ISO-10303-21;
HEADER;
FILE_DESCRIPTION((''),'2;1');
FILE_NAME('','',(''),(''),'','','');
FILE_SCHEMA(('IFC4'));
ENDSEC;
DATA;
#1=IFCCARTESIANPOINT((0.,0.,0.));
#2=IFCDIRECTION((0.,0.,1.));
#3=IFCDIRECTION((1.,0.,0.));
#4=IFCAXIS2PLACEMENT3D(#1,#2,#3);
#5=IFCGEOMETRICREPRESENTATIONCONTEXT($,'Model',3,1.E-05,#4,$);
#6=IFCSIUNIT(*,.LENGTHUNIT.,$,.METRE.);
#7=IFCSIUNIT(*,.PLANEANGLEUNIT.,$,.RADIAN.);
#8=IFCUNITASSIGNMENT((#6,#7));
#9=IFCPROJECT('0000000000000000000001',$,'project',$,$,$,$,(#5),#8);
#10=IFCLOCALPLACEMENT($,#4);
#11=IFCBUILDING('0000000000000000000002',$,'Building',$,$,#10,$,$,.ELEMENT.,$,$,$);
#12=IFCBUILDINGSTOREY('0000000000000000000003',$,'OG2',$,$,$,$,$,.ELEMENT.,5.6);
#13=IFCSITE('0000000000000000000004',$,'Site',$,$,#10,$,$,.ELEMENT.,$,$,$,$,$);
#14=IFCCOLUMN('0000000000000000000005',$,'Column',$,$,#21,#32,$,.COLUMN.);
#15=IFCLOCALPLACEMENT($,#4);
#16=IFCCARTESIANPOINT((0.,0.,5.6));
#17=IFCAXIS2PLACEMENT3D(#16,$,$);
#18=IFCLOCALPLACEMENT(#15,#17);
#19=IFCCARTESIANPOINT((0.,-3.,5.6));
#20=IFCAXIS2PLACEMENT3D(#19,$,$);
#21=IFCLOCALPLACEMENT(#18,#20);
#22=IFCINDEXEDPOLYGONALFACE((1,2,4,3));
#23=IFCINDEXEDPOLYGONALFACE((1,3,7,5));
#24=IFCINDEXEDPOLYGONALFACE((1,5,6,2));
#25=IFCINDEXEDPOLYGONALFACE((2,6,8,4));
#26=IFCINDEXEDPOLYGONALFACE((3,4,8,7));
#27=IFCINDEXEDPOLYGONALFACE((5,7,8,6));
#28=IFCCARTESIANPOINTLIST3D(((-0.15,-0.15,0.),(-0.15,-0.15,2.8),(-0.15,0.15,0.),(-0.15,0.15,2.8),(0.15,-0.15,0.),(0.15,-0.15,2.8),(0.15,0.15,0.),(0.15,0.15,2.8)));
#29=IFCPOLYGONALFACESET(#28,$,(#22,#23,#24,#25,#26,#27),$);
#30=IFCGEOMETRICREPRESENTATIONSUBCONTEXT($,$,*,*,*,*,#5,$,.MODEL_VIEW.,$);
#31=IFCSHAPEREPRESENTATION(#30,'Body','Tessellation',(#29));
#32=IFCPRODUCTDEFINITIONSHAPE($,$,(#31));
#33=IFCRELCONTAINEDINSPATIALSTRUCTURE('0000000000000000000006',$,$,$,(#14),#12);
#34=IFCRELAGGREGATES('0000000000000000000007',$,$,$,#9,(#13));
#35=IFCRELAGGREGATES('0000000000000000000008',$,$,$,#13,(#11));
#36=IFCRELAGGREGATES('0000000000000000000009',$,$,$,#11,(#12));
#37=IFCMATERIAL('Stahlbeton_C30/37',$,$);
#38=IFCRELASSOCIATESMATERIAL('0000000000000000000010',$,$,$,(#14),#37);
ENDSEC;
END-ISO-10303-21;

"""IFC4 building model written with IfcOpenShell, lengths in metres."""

from ifc_helpers import new_model, si_unit, frame, origin, origin_with_axes, origin_2d, place, context, subcontext, project, spatial, rectangle, extrude, material, element, save


model = new_model("IFC4")

# Units and contexts
model_context = context("Model", 3, precision=1e-05, world=origin_with_axes())
sub_context = subcontext(model_context, None, None, "MODEL_VIEW")
ifc_project = project(units=[si_unit("LENGTHUNIT", "METRE"), si_unit("PLANEANGLEUNIT", "RADIAN")], contexts=[model_context])

# Site, building, storey
placement_1 = place(None, origin_with_axes())
site = spatial("IfcSite", under=ifc_project, at=placement_1, Name="Site", CompositionType="ELEMENT")
building = spatial("IfcBuilding", under=site, at=placement_1, Name="Building", CompositionType="ELEMENT")
storey = spatial("IfcBuildingStorey", under=building, Name="OG2", CompositionType="ELEMENT", Elevation=5.6)

# Column
ifc_material = material(Name="Stahlbeton_C30/37")
placement_2 = place(None, origin_with_axes())
placement_3 = place(placement_2, frame((0.0, 0.0, 5.6)))
column_placement = place(placement_3, frame((0.0, -3.0, 5.6)))
element("IfcColumn", 1, at=column_placement, inside=storey, material=ifc_material, Name="Column", PredefinedType="COLUMN", context=sub_context, shape_type="SweptSolid", body=[
    extrude(rectangle(XDim=0.3, YDim=0.3, at=origin_2d()), origin(), (0.0, 0.0, 1.0), 2.8),
])

save(model, "model.ifc")
